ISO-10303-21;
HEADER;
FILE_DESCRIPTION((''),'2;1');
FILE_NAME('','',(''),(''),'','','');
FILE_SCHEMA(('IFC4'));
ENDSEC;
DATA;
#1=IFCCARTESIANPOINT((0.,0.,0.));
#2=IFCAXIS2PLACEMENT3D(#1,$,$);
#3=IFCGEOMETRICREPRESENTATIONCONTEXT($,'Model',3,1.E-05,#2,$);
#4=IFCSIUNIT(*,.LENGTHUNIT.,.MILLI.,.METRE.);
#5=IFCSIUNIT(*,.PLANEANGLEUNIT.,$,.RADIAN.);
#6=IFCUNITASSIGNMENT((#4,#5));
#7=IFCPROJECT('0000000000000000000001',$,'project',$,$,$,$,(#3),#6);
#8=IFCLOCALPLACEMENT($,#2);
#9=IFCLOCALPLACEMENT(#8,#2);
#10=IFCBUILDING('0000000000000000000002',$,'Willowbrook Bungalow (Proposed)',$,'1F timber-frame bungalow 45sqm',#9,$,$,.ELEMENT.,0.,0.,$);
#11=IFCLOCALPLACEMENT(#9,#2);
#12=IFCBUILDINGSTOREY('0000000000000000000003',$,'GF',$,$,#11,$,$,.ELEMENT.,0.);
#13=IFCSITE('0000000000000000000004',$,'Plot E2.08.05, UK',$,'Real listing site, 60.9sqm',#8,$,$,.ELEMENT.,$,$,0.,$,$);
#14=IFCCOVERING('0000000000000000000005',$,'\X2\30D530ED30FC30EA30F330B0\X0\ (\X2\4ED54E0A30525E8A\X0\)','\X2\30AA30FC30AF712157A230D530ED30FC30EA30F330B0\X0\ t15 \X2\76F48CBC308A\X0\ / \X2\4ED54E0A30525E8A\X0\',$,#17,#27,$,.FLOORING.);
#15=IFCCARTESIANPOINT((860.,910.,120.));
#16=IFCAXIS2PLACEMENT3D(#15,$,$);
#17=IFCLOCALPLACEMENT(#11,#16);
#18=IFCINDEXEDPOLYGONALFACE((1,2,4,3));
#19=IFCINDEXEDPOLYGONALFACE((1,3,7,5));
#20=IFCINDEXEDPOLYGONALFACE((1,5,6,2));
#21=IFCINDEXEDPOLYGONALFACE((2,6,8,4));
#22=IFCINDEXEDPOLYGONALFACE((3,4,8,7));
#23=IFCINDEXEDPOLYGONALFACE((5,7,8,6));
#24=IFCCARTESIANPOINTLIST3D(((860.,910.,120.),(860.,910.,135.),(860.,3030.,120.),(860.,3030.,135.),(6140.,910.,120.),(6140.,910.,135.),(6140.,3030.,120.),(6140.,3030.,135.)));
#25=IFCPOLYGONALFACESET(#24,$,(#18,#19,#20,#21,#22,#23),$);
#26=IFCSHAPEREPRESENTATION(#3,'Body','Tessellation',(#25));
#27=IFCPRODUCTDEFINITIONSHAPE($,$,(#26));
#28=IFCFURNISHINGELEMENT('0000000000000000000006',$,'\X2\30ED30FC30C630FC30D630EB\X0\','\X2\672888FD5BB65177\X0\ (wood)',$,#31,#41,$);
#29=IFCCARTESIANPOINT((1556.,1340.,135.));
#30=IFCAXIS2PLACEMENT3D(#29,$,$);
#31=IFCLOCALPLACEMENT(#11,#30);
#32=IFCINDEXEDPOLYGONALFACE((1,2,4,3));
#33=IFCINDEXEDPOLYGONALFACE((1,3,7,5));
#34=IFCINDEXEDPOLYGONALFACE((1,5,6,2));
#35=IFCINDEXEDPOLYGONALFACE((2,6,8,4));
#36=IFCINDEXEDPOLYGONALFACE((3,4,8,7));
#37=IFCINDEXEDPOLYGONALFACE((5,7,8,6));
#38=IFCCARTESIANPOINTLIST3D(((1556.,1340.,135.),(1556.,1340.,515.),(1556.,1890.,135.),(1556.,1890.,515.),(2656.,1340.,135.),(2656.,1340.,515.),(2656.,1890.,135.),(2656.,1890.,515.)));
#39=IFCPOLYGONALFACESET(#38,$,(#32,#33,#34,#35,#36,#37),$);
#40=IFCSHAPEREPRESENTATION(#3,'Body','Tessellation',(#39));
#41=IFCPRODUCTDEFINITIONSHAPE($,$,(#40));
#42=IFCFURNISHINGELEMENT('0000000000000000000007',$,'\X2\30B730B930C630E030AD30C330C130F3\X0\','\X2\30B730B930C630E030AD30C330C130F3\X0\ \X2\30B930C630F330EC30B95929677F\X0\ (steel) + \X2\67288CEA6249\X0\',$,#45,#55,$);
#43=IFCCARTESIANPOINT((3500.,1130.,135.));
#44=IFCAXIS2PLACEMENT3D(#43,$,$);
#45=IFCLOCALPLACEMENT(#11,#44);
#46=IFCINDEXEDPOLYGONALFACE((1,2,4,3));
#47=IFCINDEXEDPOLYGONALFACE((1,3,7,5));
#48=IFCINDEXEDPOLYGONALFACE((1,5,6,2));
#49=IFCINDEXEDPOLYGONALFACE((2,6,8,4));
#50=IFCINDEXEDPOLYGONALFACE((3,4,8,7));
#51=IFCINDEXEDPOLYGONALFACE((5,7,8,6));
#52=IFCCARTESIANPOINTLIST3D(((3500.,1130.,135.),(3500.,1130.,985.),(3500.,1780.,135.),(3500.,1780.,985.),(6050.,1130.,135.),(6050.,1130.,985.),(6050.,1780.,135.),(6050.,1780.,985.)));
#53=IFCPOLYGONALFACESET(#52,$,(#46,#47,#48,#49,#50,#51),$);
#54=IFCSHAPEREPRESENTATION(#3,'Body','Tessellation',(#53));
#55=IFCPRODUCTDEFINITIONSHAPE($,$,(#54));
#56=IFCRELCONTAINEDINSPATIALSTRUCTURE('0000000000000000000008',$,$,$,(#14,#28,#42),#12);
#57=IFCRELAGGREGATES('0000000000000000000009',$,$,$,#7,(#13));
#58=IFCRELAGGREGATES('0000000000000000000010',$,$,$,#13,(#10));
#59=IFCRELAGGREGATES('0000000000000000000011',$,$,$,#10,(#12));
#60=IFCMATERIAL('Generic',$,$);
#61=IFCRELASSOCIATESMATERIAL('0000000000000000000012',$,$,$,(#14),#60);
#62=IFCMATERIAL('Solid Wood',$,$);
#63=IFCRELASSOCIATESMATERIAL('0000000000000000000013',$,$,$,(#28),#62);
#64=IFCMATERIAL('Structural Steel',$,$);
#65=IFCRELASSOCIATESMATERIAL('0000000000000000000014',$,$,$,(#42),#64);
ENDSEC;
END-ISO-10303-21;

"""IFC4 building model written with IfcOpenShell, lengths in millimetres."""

from ifc_helpers import new_model, si_unit, frame, frame_2d, origin, place, context, project, spatial, rectangle, extrude, material, element, save


model = new_model("IFC4")

# Units and contexts
model_context = context("Model", 3, precision=1e-05, world=origin())
ifc_project = project(units=[si_unit("LENGTHUNIT", "METRE", prefix="MILLI"), si_unit("PLANEANGLEUNIT", "RADIAN")], contexts=[model_context])

# Site, building, storey
site_placement = place(None, origin())
site = spatial("IfcSite", under=ifc_project, at=site_placement, Name="Plot E2.08.05, UK", ObjectType="Real listing site, 60.9sqm", CompositionType="ELEMENT", RefElevation=0.0)
building_placement = place(site_placement, origin())
building = spatial("IfcBuilding", under=site, at=building_placement, Name="Willowbrook Bungalow (Proposed)", ObjectType="1F timber-frame bungalow 45sqm", CompositionType="ELEMENT", ElevationOfRefHeight=0.0, ElevationOfTerrain=0.0)
storey_placement = place(building_placement, origin())
storey = spatial("IfcBuildingStorey", under=building, at=storey_placement, Name="GF", CompositionType="ELEMENT", Elevation=0.0)

# Shared definitions
ifc_material_1 = material(Name="Solid Wood")

# Covering
ifc_material_2 = material(Name="Generic")
covering_placement = place(storey_placement, frame((860.0, 910.0, 120.0)))
element("IfcCovering", 1, at=covering_placement, inside=storey, material=ifc_material_2, Name="フローリング (仕上げ床)", Description="オーク無垢フローリング t15 直貼り / 仕上げ床", PredefinedType="FLOORING", context=model_context, shape_type="SweptSolid", body=[
    extrude(rectangle(XDim=5280.0, YDim=2120.0, at=frame_2d((2640.0, 1060.0))), frame((860.0, 910.0, 120.0)), (0.0, 0.0, 1.0), 15.0),
])

# Furnishing elements
furnishing_1_placement = place(storey_placement, frame((1556.0, 1340.0, 135.0)))
element("IfcFurnishingElement", 2, at=furnishing_1_placement, inside=storey, material=ifc_material_1, Name="ローテーブル", Description="木製家具 (wood)", context=model_context, shape_type="SweptSolid", body=[
    extrude(rectangle(XDim=1100.0, YDim=550.0, at=frame_2d((550.0, 275.0))), frame((1556.0, 1340.0, 135.0)), (0.0, 0.0, 1.0), 380.0),
])
ifc_material_3 = material(Name="Structural Steel")
furnishing_2_placement = place(storey_placement, frame((3500.0, 1130.0, 135.0)))
element("IfcFurnishingElement", 3, at=furnishing_2_placement, inside=storey, material=ifc_material_3, Name="システムキッチン", Description="システムキッチン ステンレス天板 (steel) + 木質扉", context=model_context, shape_type="SweptSolid", body=[
    extrude(rectangle(XDim=2550.0, YDim=650.0, at=frame_2d((1275.0, 325.0))), frame((3500.0, 1130.0, 135.0)), (0.0, 0.0, 1.0), 850.0),
])

save(model, "model.ifc")
